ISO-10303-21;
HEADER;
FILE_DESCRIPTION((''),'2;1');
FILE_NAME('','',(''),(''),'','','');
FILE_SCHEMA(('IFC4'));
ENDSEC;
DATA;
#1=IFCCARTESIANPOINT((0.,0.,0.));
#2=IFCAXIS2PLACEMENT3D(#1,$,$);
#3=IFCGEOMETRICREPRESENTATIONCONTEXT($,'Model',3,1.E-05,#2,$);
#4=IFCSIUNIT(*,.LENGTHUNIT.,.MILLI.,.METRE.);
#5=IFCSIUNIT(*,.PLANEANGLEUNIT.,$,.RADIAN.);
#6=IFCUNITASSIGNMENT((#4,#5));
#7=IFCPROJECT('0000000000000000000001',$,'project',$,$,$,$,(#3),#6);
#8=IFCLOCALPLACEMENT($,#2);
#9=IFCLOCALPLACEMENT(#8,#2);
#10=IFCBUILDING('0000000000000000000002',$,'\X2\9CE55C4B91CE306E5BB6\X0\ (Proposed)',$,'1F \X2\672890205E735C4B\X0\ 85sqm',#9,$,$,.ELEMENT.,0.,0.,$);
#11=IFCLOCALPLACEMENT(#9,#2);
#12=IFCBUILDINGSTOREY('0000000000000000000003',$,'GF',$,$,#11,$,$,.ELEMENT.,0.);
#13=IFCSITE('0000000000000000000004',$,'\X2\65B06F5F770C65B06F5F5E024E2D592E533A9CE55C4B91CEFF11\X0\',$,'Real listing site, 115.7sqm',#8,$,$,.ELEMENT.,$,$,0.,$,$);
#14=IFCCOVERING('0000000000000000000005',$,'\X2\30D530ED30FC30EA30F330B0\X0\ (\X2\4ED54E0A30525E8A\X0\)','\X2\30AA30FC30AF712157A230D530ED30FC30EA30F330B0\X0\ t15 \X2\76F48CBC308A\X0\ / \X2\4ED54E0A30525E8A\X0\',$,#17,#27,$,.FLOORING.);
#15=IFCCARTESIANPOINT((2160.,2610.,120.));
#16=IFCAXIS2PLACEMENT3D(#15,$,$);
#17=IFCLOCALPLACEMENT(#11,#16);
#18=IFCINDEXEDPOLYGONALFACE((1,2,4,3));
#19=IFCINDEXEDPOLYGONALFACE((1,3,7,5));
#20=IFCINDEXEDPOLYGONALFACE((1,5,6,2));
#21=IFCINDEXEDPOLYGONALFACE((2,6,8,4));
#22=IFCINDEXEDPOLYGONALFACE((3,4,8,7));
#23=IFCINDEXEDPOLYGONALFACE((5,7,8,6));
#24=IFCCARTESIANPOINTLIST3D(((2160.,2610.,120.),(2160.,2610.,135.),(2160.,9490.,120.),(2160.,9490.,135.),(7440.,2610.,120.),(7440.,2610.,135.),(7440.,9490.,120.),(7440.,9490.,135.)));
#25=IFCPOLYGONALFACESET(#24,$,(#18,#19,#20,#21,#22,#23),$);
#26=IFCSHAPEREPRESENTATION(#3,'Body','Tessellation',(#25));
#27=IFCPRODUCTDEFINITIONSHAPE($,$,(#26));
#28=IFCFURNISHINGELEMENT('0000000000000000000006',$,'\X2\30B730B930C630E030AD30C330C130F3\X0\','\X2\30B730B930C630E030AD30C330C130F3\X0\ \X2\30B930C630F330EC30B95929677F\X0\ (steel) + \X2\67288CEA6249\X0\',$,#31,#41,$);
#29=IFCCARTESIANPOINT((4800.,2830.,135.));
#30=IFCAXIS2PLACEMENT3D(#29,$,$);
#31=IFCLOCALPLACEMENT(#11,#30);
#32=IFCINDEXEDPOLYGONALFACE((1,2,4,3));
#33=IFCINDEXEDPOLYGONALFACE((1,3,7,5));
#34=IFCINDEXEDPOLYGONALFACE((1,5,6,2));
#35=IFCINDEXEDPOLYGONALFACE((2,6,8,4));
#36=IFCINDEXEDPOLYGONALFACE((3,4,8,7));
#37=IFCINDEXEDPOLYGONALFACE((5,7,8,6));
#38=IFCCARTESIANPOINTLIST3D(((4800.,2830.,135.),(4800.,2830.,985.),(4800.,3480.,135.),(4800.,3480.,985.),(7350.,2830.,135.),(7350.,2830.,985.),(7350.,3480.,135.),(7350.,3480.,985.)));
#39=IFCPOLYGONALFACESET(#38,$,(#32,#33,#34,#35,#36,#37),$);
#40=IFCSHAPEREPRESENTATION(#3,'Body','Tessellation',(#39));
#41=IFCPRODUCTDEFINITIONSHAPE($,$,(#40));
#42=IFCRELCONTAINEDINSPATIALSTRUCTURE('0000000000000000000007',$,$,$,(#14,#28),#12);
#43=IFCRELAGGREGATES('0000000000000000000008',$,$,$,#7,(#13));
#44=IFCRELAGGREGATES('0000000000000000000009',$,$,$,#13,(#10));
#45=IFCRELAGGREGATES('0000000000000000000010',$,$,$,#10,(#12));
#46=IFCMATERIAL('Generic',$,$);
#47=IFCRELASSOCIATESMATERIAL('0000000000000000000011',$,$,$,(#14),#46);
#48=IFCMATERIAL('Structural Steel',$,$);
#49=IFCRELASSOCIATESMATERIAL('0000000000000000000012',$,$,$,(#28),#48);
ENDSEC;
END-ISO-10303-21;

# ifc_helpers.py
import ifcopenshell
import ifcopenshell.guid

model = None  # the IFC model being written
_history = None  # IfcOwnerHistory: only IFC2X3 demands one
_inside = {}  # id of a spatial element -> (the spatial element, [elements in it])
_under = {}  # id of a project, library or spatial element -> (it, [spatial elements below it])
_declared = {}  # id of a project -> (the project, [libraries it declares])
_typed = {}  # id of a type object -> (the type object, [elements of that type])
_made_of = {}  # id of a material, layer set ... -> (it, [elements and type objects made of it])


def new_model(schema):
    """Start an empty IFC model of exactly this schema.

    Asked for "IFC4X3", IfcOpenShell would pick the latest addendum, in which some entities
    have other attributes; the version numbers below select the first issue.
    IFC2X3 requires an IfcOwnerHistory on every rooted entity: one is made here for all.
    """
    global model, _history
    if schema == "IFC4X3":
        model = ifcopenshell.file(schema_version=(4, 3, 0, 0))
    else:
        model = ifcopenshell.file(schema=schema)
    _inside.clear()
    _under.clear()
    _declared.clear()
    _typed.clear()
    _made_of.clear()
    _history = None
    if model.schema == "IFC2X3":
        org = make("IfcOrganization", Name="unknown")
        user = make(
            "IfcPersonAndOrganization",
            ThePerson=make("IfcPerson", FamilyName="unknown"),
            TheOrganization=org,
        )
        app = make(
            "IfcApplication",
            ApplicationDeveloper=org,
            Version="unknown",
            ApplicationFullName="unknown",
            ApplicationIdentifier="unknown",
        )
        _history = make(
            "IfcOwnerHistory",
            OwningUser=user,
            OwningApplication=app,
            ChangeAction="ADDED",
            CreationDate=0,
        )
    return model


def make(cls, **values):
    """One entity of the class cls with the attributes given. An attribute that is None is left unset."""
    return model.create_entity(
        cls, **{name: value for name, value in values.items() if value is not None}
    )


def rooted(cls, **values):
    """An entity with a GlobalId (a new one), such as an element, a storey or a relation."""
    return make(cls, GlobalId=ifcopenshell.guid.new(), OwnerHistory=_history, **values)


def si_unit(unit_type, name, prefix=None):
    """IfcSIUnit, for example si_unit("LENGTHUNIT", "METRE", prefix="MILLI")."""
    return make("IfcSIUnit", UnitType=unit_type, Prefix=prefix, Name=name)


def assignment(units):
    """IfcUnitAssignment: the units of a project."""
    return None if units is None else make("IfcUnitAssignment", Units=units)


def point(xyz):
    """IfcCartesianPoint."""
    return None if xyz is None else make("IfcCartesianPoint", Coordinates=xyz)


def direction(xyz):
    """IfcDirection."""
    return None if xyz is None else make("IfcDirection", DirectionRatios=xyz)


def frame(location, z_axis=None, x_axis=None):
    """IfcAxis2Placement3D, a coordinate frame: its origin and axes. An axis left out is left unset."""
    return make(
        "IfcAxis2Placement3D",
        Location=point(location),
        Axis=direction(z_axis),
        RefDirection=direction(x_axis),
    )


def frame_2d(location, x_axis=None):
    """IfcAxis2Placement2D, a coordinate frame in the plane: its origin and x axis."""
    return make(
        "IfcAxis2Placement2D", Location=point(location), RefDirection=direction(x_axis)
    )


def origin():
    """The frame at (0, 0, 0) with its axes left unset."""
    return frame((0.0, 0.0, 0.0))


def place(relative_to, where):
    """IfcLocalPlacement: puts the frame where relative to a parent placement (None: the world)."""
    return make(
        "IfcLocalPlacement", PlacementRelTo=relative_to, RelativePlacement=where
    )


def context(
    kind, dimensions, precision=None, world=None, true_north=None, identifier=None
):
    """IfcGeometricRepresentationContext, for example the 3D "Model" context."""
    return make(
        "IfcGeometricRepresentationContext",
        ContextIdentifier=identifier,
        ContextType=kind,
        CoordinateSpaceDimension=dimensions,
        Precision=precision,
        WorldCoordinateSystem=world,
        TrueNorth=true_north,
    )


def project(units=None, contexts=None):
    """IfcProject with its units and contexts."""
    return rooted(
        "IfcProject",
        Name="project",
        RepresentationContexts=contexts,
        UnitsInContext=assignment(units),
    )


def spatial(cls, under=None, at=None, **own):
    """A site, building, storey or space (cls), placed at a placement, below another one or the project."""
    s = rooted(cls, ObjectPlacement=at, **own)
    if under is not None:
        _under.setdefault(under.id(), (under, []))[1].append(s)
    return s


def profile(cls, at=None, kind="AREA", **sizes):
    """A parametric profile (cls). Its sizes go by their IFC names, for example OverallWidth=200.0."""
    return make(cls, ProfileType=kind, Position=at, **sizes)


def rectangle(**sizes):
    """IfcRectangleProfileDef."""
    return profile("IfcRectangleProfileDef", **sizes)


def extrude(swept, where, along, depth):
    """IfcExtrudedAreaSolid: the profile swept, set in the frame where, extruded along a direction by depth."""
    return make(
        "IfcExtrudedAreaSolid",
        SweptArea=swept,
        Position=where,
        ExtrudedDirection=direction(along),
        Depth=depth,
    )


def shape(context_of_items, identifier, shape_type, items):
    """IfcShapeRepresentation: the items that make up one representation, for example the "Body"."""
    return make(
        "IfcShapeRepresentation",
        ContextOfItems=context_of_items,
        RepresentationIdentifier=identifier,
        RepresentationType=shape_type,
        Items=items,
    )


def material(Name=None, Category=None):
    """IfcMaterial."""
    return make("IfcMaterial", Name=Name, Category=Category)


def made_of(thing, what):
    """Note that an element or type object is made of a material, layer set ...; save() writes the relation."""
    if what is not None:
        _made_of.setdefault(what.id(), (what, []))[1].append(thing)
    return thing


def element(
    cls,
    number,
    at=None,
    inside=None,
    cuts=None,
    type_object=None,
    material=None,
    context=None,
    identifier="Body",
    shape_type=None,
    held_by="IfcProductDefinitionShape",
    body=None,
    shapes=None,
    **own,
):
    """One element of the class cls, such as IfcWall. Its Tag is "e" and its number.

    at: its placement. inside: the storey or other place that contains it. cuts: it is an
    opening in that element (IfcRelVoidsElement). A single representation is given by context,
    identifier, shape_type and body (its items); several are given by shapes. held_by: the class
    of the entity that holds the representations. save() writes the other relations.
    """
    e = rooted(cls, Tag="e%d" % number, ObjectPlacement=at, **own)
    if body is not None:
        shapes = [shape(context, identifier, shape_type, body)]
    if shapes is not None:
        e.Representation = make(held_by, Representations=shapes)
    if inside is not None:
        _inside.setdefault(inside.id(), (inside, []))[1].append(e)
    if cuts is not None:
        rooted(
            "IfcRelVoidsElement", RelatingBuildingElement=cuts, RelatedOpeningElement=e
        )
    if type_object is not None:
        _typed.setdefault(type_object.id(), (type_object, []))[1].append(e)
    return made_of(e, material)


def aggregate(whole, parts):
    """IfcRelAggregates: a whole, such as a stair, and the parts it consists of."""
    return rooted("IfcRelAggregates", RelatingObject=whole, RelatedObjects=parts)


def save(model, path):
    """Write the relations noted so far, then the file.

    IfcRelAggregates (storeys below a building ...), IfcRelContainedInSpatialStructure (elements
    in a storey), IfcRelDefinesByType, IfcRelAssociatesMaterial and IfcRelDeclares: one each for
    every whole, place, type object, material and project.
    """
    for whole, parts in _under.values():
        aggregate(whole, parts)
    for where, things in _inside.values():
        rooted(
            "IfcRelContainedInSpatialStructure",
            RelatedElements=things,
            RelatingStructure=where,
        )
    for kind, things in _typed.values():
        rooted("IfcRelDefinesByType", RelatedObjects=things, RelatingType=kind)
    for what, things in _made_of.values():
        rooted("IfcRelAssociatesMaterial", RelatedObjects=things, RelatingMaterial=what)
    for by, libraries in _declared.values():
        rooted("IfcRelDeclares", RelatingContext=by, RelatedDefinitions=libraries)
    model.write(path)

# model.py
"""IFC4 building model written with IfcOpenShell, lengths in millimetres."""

from ifc_helpers import new_model, si_unit, frame, frame_2d, origin, place, context, project, spatial, rectangle, extrude, material, element, save


model = new_model("IFC4")

# Units and contexts
model_context = context("Model", 3, precision=1e-05, world=origin())
ifc_project = project(units=[si_unit("LENGTHUNIT", "METRE", prefix="MILLI"), si_unit("PLANEANGLEUNIT", "RADIAN")], contexts=[model_context])

# Site, building, storey
site_placement = place(None, origin())
site = spatial("IfcSite", under=ifc_project, at=site_placement, Name="新潟県新潟市中央区鳥屋野１", ObjectType="Real listing site, 115.7sqm", CompositionType="ELEMENT", RefElevation=0.0)
building_placement = place(site_placement, origin())
building = spatial("IfcBuilding", under=site, at=building_placement, Name="鳥屋野の家 (Proposed)", ObjectType="1F 木造平屋 85sqm", CompositionType="ELEMENT", ElevationOfRefHeight=0.0, ElevationOfTerrain=0.0)
storey_placement = place(building_placement, origin())
storey = spatial("IfcBuildingStorey", under=building, at=storey_placement, Name="GF", CompositionType="ELEMENT", Elevation=0.0)

# Shared definitions
ifc_material_1 = material(Name="Generic")

# Covering
covering_placement = place(storey_placement, frame((2160.0, 2610.0, 120.0)))
element("IfcCovering", 1, at=covering_placement, inside=storey, material=ifc_material_1, Name="フローリング (仕上げ床)", Description="オーク無垢フローリング t15 直貼り / 仕上げ床", PredefinedType="FLOORING", context=model_context, shape_type="SweptSolid", body=[
    extrude(rectangle(XDim=5280.0, YDim=6880.0, at=frame_2d((2640.0, 3440.0))), frame((2160.0, 2610.0, 120.0)), (0.0, 0.0, 1.0), 15.0),
])

# Furnishing element
ifc_material_2 = material(Name="Structural Steel")
furnishing_placement = place(storey_placement, frame((4800.0, 2830.0, 135.0)))
element("IfcFurnishingElement", 2, at=furnishing_placement, inside=storey, material=ifc_material_2, Name="システムキッチン", Description="システムキッチン ステンレス天板 (steel) + 木質扉", context=model_context, shape_type="SweptSolid", body=[
    extrude(rectangle(XDim=2550.0, YDim=650.0, at=frame_2d((1275.0, 325.0))), frame((4800.0, 2830.0, 135.0)), (0.0, 0.0, 1.0), 850.0),
])

save(model, "model.ifc")
